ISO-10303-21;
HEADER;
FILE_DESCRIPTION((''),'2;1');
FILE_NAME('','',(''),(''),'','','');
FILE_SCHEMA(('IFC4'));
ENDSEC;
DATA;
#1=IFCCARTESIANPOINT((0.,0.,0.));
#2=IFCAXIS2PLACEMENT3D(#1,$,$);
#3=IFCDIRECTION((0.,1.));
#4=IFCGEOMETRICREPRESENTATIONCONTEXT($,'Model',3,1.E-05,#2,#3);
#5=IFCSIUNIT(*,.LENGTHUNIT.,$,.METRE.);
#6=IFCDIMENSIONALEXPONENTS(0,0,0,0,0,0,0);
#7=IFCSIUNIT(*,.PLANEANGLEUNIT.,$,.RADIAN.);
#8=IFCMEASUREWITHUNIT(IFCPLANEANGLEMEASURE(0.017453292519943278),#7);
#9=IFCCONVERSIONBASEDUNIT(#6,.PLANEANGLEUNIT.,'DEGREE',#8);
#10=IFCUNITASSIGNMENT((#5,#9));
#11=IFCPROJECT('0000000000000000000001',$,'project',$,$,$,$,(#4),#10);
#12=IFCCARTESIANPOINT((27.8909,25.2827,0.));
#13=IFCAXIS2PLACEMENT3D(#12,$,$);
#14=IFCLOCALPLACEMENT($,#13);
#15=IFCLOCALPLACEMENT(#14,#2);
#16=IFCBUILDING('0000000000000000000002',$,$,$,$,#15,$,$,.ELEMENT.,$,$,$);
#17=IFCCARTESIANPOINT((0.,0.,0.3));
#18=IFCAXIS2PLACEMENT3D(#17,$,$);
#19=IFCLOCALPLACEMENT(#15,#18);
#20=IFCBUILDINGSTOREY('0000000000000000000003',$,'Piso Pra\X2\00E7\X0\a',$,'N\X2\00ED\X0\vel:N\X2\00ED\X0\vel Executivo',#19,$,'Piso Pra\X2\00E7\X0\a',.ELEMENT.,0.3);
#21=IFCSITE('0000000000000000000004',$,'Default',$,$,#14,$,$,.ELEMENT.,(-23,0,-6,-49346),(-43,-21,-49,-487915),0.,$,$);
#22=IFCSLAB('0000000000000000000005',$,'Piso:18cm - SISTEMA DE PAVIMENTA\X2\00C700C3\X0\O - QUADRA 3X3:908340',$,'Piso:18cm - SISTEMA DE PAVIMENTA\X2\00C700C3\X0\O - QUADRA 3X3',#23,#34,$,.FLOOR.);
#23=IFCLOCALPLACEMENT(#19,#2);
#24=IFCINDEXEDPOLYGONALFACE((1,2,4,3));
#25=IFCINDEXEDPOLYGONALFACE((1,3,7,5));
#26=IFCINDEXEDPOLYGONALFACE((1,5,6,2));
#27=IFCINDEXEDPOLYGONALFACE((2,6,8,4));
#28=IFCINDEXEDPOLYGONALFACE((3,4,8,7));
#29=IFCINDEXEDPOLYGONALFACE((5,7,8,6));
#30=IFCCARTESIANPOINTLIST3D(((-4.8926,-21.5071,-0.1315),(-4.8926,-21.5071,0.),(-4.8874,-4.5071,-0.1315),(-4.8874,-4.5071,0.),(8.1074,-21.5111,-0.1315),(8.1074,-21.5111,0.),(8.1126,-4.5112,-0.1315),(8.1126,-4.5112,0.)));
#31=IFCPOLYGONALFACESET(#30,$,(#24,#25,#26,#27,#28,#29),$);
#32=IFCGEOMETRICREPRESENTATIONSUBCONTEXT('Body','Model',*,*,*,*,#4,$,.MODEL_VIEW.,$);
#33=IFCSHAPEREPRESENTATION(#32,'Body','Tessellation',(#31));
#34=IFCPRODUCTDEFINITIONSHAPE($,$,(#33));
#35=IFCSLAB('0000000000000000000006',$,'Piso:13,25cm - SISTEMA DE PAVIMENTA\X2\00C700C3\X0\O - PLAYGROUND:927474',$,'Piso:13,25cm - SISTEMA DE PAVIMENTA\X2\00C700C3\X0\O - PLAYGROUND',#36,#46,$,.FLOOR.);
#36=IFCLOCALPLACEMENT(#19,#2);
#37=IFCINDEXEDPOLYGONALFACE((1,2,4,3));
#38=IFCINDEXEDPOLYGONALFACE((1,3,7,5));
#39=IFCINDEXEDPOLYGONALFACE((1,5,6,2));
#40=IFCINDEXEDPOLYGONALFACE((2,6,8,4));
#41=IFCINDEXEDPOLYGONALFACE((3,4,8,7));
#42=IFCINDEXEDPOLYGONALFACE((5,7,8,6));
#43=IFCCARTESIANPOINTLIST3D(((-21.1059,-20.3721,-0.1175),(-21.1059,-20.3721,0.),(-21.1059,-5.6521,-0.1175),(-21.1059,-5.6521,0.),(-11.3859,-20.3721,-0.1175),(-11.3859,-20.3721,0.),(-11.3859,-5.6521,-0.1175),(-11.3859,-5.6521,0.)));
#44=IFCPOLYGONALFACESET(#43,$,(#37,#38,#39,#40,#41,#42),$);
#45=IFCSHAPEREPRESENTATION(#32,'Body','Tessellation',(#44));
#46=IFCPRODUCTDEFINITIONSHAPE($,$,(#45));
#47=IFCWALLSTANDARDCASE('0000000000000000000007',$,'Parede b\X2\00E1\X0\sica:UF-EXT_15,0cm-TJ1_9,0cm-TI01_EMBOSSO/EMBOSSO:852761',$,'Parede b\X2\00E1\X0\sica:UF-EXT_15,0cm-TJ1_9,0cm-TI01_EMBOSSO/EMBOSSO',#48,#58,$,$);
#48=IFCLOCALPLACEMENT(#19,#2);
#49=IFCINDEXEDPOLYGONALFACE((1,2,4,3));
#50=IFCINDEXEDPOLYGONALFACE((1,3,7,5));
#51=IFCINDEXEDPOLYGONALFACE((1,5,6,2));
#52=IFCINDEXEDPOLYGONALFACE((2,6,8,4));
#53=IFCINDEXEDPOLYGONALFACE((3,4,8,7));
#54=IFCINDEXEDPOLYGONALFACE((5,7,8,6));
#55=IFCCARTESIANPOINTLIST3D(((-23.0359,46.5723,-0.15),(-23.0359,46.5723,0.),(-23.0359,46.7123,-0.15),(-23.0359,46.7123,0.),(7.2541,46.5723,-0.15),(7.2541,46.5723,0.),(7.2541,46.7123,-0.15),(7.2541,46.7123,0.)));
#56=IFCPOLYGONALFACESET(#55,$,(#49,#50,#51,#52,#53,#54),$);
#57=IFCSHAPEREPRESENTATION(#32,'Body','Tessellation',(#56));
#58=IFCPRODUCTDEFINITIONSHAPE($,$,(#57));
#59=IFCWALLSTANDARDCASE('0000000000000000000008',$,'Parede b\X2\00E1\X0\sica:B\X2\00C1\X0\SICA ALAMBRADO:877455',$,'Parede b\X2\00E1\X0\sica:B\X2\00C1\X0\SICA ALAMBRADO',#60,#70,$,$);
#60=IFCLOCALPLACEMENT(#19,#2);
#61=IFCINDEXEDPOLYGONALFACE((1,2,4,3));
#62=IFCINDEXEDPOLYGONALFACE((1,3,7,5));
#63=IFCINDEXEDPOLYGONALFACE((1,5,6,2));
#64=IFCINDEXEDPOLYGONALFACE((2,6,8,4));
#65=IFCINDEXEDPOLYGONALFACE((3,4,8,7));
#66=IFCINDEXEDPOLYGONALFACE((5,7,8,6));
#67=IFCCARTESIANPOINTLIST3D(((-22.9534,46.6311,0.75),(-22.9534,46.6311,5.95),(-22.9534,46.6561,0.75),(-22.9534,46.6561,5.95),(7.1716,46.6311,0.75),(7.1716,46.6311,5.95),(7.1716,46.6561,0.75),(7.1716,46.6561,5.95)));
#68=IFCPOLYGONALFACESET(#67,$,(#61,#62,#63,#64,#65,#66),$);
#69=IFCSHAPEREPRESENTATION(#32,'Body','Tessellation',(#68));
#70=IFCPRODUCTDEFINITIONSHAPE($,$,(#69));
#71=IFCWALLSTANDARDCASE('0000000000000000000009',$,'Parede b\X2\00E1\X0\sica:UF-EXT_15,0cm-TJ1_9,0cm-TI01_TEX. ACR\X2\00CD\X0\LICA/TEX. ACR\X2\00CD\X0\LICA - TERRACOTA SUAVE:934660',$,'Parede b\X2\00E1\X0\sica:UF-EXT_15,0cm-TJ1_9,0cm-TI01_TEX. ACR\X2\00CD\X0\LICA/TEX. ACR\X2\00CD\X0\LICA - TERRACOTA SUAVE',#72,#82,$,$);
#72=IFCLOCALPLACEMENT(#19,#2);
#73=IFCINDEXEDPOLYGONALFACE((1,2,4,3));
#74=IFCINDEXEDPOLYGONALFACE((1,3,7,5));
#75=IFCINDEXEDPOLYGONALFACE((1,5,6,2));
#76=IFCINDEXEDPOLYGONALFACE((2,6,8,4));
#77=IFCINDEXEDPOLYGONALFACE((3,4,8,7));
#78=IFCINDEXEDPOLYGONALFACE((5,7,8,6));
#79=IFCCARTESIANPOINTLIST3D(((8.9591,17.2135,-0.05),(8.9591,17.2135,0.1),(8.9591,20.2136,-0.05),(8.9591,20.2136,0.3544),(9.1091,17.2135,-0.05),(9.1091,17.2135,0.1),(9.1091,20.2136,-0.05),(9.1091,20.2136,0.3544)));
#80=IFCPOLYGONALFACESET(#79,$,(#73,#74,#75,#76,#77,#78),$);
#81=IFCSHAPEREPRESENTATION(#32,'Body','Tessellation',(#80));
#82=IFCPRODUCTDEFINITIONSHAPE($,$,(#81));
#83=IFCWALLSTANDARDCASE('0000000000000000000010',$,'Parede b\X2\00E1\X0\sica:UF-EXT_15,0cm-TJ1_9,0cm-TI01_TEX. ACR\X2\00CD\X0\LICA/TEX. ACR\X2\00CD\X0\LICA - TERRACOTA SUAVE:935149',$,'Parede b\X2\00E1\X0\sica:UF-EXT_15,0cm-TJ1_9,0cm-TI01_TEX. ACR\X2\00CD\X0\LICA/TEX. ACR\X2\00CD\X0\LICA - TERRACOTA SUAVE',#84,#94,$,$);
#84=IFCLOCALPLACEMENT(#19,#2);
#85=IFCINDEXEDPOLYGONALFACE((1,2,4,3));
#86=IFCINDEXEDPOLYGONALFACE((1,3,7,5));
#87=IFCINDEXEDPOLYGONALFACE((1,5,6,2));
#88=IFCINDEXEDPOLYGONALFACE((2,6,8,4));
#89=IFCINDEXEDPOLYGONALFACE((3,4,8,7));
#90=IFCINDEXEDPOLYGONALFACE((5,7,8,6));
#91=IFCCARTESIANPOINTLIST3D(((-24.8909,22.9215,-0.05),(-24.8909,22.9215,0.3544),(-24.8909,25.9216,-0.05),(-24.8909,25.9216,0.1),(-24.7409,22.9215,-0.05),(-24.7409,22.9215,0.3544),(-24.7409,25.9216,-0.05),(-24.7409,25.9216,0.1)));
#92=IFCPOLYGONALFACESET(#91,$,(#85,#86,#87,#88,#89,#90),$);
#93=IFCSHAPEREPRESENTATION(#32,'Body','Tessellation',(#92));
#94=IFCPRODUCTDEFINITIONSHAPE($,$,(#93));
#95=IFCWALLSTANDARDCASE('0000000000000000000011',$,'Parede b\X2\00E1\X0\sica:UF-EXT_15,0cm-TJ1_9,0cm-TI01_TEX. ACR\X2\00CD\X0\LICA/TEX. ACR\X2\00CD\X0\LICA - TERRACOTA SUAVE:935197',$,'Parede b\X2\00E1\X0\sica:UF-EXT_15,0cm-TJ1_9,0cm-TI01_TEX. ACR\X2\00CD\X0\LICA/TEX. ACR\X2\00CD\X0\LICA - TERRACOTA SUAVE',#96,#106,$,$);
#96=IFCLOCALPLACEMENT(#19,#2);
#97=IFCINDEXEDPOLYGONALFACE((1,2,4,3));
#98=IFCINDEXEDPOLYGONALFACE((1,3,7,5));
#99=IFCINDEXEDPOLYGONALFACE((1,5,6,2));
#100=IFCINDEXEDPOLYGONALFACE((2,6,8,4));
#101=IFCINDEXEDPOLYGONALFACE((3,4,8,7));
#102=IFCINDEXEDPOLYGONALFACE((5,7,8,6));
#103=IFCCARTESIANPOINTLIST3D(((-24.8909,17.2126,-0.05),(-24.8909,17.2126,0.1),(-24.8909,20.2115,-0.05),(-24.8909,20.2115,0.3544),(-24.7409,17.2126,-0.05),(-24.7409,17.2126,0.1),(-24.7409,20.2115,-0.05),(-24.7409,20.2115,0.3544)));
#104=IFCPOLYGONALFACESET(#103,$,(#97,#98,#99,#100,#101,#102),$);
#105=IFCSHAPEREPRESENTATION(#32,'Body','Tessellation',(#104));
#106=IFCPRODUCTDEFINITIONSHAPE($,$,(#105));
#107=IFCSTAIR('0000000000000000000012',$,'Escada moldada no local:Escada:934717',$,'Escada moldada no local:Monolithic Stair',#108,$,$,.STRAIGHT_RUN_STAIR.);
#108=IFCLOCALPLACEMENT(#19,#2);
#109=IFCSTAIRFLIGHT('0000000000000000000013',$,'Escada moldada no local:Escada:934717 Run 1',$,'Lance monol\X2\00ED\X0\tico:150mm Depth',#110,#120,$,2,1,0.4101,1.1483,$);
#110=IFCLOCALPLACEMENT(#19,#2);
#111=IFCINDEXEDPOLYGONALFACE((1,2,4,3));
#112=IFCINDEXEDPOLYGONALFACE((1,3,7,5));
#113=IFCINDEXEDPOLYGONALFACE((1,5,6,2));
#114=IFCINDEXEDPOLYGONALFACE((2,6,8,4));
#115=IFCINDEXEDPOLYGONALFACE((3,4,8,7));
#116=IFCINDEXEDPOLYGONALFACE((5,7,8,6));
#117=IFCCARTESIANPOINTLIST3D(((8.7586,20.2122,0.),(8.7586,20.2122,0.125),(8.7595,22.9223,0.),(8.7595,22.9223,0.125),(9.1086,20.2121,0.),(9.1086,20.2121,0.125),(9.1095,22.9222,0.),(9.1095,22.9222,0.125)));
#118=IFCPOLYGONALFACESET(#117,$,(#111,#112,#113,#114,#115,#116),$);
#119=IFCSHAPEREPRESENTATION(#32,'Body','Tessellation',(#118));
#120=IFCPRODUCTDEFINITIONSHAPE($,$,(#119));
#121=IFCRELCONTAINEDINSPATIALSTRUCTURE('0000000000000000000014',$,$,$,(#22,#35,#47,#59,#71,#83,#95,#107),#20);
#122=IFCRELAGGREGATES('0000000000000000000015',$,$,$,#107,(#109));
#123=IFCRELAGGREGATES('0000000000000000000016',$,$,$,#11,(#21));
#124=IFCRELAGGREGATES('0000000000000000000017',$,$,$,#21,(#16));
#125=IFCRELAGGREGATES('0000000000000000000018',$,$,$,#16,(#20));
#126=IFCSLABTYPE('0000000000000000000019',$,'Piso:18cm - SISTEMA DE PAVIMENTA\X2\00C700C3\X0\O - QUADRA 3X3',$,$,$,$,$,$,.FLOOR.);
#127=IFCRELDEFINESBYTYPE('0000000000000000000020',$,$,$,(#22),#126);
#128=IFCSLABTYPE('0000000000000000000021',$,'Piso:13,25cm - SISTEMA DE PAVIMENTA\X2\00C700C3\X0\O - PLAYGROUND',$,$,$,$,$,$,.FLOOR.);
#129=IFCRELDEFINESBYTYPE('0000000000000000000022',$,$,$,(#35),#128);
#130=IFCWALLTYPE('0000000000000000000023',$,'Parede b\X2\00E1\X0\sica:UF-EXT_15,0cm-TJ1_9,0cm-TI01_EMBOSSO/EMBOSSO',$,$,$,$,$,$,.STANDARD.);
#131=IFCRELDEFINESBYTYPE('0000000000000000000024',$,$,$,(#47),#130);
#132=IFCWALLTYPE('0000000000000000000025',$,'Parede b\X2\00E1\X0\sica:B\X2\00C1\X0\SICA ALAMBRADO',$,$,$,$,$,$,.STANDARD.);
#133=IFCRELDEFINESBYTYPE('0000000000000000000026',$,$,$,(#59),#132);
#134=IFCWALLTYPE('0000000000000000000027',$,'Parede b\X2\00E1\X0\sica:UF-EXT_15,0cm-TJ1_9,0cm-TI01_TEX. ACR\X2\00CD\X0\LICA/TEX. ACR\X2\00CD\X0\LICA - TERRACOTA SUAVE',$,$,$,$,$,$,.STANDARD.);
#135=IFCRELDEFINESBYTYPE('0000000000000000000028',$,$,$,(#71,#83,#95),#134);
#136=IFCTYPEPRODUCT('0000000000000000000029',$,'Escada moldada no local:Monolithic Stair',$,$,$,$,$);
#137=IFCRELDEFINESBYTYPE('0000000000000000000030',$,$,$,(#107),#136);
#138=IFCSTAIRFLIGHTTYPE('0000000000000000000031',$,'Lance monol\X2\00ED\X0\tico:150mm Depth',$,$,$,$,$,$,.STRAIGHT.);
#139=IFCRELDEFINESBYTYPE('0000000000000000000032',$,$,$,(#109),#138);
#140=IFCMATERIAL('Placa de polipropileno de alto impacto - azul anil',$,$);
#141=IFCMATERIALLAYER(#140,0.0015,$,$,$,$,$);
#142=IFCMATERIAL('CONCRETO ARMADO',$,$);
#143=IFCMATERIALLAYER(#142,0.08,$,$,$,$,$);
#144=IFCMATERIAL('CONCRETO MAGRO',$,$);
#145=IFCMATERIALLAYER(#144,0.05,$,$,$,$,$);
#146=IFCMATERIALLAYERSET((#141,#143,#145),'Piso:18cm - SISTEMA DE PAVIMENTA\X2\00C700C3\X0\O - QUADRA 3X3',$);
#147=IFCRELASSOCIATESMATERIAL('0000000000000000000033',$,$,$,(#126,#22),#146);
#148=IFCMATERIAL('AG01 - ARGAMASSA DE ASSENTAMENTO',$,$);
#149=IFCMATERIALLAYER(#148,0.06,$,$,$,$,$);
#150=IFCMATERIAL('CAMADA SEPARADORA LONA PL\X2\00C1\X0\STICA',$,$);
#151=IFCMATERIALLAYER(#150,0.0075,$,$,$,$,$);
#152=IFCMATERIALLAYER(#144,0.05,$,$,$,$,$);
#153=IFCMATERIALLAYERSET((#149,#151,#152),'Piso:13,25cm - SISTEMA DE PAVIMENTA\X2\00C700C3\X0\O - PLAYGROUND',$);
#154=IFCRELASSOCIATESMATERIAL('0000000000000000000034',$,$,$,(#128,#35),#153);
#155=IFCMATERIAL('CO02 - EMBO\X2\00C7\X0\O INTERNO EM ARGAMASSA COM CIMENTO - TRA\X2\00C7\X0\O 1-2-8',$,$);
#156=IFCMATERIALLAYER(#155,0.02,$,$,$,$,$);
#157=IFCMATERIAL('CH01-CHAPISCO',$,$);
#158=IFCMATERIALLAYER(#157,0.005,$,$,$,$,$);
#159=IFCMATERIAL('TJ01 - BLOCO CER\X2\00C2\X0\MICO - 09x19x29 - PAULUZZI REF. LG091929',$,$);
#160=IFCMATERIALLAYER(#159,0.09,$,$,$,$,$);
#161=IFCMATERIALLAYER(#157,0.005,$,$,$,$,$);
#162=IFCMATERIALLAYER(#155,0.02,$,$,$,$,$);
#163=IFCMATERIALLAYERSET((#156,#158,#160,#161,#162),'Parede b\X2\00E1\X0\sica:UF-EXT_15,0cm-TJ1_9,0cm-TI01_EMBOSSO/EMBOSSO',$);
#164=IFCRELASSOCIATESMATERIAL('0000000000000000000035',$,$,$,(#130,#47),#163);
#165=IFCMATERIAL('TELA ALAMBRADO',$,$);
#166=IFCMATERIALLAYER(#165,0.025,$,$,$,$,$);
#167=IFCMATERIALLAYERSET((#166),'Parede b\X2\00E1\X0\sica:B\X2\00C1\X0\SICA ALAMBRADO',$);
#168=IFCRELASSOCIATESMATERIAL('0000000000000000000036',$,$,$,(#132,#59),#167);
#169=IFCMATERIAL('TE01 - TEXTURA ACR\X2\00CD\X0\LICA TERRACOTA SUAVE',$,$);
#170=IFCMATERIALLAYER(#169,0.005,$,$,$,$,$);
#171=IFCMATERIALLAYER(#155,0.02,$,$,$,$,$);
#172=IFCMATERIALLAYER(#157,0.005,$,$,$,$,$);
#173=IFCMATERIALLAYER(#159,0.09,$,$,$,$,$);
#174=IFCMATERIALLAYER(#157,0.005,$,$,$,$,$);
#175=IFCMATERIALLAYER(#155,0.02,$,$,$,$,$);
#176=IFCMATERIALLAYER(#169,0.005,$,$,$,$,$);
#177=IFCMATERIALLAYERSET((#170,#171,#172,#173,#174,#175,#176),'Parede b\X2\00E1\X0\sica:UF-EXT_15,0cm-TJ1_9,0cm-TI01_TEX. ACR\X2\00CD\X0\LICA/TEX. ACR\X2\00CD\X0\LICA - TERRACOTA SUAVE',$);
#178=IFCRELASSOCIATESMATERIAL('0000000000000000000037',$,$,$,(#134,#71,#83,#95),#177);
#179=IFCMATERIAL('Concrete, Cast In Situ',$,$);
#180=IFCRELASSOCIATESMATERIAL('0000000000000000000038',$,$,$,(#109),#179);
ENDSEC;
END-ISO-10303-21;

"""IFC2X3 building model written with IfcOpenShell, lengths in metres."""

from ifc_helpers import new_model, entity, si_unit, converted_unit, direction, frame, frame_2d, origin, origin_2d_with_axis, place, context, subcontext, project, spatial, rectangle, extrude, clip, halfspace, material, layer, layer_set, layer_usage, type_object, element, aggregate, save


model = new_model("IFC2X3")

# Units and contexts
model_context = context("Model", 3, precision=1e-05, world=origin(), true_north=direction((0.0, 1.0)))
body_context = subcontext(model_context, "Body", "Model", "MODEL_VIEW")
ifc_project = project(units=[si_unit("LENGTHUNIT", "METRE"), converted_unit("PLANEANGLEUNIT", "DEGREE", entity("IfcPlaneAngleMeasure", 0.017453292519943278), si_unit("PLANEANGLEUNIT", "RADIAN"), dimensions=[0, 0, 0, 0, 0, 0, 0])], contexts=[model_context])

# Site, building, storey
site_placement = place(None, frame((27.8909, 25.2827, 0.0)))
site = spatial("IfcSite", under=ifc_project, at=site_placement, Name="Default", CompositionType="ELEMENT", RefLatitude=(-23, 0, -6, -49346), RefLongitude=(-43, -21, -49, -487915), RefElevation=0.0)
building_placement = place(site_placement, origin())
building = spatial("IfcBuilding", under=site, at=building_placement, CompositionType="ELEMENT")
storey_placement = place(building_placement, frame((0.0, 0.0, 0.3)))
storey = spatial("IfcBuildingStorey", under=building, at=storey_placement, Name="Piso Praça", ObjectType="Nível:Nível Executivo", LongName="Piso Praça", CompositionType="ELEMENT", Elevation=0.3)

# Slabs
ifc_material_1 = material(Name="CONCRETO ARMADO")
ifc_material_2 = material(Name="CONCRETO MAGRO")
ifc_material_3 = material(Name="Placa de polipropileno de alto impacto - azul anil")
ifc_layer_1 = layer(ifc_material_3, 0.0015)
ifc_layer_2 = layer(ifc_material_1, 0.08)
ifc_layer_3 = layer(ifc_material_2, 0.05)
ifc_layer_set_1 = layer_set([ifc_layer_1, ifc_layer_2, ifc_layer_3], Name="Piso:18cm - SISTEMA DE PAVIMENTAÇÃO - QUADRA 3X3")
ifc_layer_usage_1 = layer_usage(ifc_layer_set_1, "AXIS3", "POSITIVE", 0.0)
slab_type_1 = type_object("IfcSlabType", Name="Piso:18cm - SISTEMA DE PAVIMENTAÇÃO - QUADRA 3X3", PredefinedType="FLOOR", material=ifc_layer_set_1)
slab_1_placement = place(storey_placement, origin())
element("IfcSlab", 1, at=slab_1_placement, inside=storey, type_object=slab_type_1, material=ifc_layer_usage_1, Name="Piso:18cm - SISTEMA DE PAVIMENTAÇÃO - QUADRA 3X3:908340", ObjectType="Piso:18cm - SISTEMA DE PAVIMENTAÇÃO - QUADRA 3X3", PredefinedType="FLOOR", context=body_context, shape_type="SweptSolid", body=[
    extrude(rectangle(XDim=13.0, YDim=17.0, at=frame_2d((0.0, 0.0), x_axis=(1.0, 0.0))), frame((1.61, -13.0091, 0.0), z_axis=(0.0, 0.0, -1.0), x_axis=(1.0, -0.00031, 0.0)), (0.0, 0.0, 1.0), 0.1315),
])
ifc_material_4 = material(Name="AG01 - ARGAMASSA DE ASSENTAMENTO")
ifc_layer_4 = layer(ifc_material_4, 0.06)
ifc_material_5 = material(Name="CAMADA SEPARADORA LONA PLÁSTICA")
ifc_layer_5 = layer(ifc_material_5, 0.0075)
ifc_layer_6 = layer(ifc_material_2, 0.05)
ifc_layer_set_2 = layer_set([ifc_layer_4, ifc_layer_5, ifc_layer_6], Name="Piso:13,25cm - SISTEMA DE PAVIMENTAÇÃO - PLAYGROUND")
ifc_layer_usage_2 = layer_usage(ifc_layer_set_2, "AXIS3", "POSITIVE", 0.0)
slab_type_2 = type_object("IfcSlabType", Name="Piso:13,25cm - SISTEMA DE PAVIMENTAÇÃO - PLAYGROUND", PredefinedType="FLOOR", material=ifc_layer_set_2)
slab_2_placement = place(storey_placement, origin())
element("IfcSlab", 2, at=slab_2_placement, inside=storey, type_object=slab_type_2, material=ifc_layer_usage_2, Name="Piso:13,25cm - SISTEMA DE PAVIMENTAÇÃO - PLAYGROUND:927474", ObjectType="Piso:13,25cm - SISTEMA DE PAVIMENTAÇÃO - PLAYGROUND", PredefinedType="FLOOR", context=body_context, shape_type="SweptSolid", body=[
    extrude(rectangle(XDim=14.72, YDim=9.72, at=origin_2d_with_axis()), frame((-16.2459, -13.0121, 0.0), z_axis=(0.0, 0.0, -1.0), x_axis=(0.0, 1.0, 0.0)), (0.0, 0.0, 1.0), 0.1175),
])

# Walls
ifc_material_6 = material(Name="CO02 - EMBOÇO INTERNO EM ARGAMASSA COM CIMENTO - TRAÇO 1-2-8")
ifc_layer_7 = layer(ifc_material_6, 0.02)
ifc_material_7 = material(Name="CH01-CHAPISCO")
ifc_layer_8 = layer(ifc_material_7, 0.005)
ifc_material_8 = material(Name="TJ01 - BLOCO CERÂMICO - 09x19x29 - PAULUZZI REF. LG091929")
ifc_layer_9 = layer(ifc_material_8, 0.09)
ifc_layer_10 = layer(ifc_material_7, 0.005)
ifc_layer_11 = layer(ifc_material_6, 0.02)
ifc_layer_set_3 = layer_set([ifc_layer_7, ifc_layer_8, ifc_layer_9, ifc_layer_10, ifc_layer_11], Name="Parede básica:UF-EXT_15,0cm-TJ1_9,0cm-TI01_EMBOSSO/EMBOSSO")
ifc_layer_usage_3 = layer_usage(ifc_layer_set_3, "AXIS2", "NEGATIVE", 0.07)
wall_type_1 = type_object("IfcWallType", Name="Parede básica:UF-EXT_15,0cm-TJ1_9,0cm-TI01_EMBOSSO/EMBOSSO", PredefinedType="STANDARD", material=ifc_layer_set_3)
wall_1_placement = place(storey_placement, frame((-23.0359, 46.6423, -0.15)))
element("IfcWallStandardCase", 3, at=wall_1_placement, inside=storey, type_object=wall_type_1, material=ifc_layer_usage_3, Name="Parede básica:UF-EXT_15,0cm-TJ1_9,0cm-TI01_EMBOSSO/EMBOSSO:852761", ObjectType="Parede básica:UF-EXT_15,0cm-TJ1_9,0cm-TI01_EMBOSSO/EMBOSSO", context=body_context, shape_type="SweptSolid", body=[
    extrude(rectangle(XDim=30.29, YDim=0.14, at=frame_2d((15.145, 0.0), x_axis=(-1.0, 0.0))), origin(), (0.0, 0.0, 1.0), 0.15),
])
ifc_material_9 = material(Name="TELA ALAMBRADO")
ifc_layer_12 = layer(ifc_material_9, 0.025)
ifc_layer_set_4 = layer_set([ifc_layer_12], Name="Parede básica:BÁSICA ALAMBRADO")
ifc_layer_usage_4 = layer_usage(ifc_layer_set_4, "AXIS2", "NEGATIVE", 0.0125)
wall_type_2 = type_object("IfcWallType", Name="Parede básica:BÁSICA ALAMBRADO", PredefinedType="STANDARD", material=ifc_layer_set_4)
wall_2_placement = place(storey_placement, frame((-22.9534, 46.6436, 0.75)))
element("IfcWallStandardCase", 4, at=wall_2_placement, inside=storey, type_object=wall_type_2, material=ifc_layer_usage_4, Name="Parede básica:BÁSICA ALAMBRADO:877455", ObjectType="Parede básica:BÁSICA ALAMBRADO", context=body_context, shape_type="SweptSolid", body=[
    extrude(rectangle(XDim=30.125, YDim=0.025, at=frame_2d((15.0625, 0.0), x_axis=(-1.0, 0.0))), origin(), (0.0, 0.0, 1.0), 5.2),
])

# Walls
ifc_material_10 = material(Name="TE01 - TEXTURA ACRÍLICA TERRACOTA SUAVE")
ifc_layer_13 = layer(ifc_material_10, 0.005)
ifc_layer_14 = layer(ifc_material_6, 0.02)
ifc_layer_15 = layer(ifc_material_7, 0.005)
ifc_layer_16 = layer(ifc_material_8, 0.09)
ifc_layer_17 = layer(ifc_material_7, 0.005)
ifc_layer_18 = layer(ifc_material_6, 0.02)
ifc_layer_19 = layer(ifc_material_10, 0.005)
ifc_layer_set_5 = layer_set([ifc_layer_13, ifc_layer_14, ifc_layer_15, ifc_layer_16, ifc_layer_17, ifc_layer_18, ifc_layer_19], Name="Parede básica:UF-EXT_15,0cm-TJ1_9,0cm-TI01_TEX. ACRÍLICA/TEX. ACRÍLICA - TERRACOTA SUAVE")
ifc_layer_usage_5 = layer_usage(ifc_layer_set_5, "AXIS2", "NEGATIVE", 0.075)
wall_type_3 = type_object("IfcWallType", Name="Parede básica:UF-EXT_15,0cm-TJ1_9,0cm-TI01_TEX. ACRÍLICA/TEX. ACRÍLICA - TERRACOTA SUAVE", PredefinedType="STANDARD", material=ifc_layer_set_5)
wall_3_placement = place(storey_placement, frame((9.0341, 20.2136, -0.05), z_axis=(0.0, 0.0, 1.0), x_axis=(0.0, -1.0, 0.0)))
element("IfcWallStandardCase", 5, at=wall_3_placement, inside=storey, type_object=wall_type_3, material=ifc_layer_usage_5, Name="Parede básica:UF-EXT_15,0cm-TJ1_9,0cm-TI01_TEX. ACRÍLICA/TEX. ACRÍLICA - TERRACOTA SUAVE:934660", ObjectType="Parede básica:UF-EXT_15,0cm-TJ1_9,0cm-TI01_TEX. ACRÍLICA/TEX. ACRÍLICA - TERRACOTA SUAVE", context=body_context, shape_type="Clipping", body=[
    clip(extrude(rectangle(XDim=3.0001, YDim=0.15, at=frame_2d((1.5, 0.0), x_axis=(-1.0, 0.0))), origin(), (0.0, 0.0, 1.0), 0.4044), halfspace(frame((0.0, -0.075, 0.4044), z_axis=(0.084506, 0.0, 0.996423), x_axis=(0.0, 1.0, 0.0)), False)),
])
wall_4_placement = place(storey_placement, frame((-24.8159, 22.9215, -0.05), z_axis=(0.0, 0.0, 1.0), x_axis=(0.0, 1.0, 0.0)))
element("IfcWallStandardCase", 6, at=wall_4_placement, inside=storey, type_object=wall_type_3, material=ifc_layer_usage_5, Name="Parede básica:UF-EXT_15,0cm-TJ1_9,0cm-TI01_TEX. ACRÍLICA/TEX. ACRÍLICA - TERRACOTA SUAVE:935149", ObjectType="Parede básica:UF-EXT_15,0cm-TJ1_9,0cm-TI01_TEX. ACRÍLICA/TEX. ACRÍLICA - TERRACOTA SUAVE", context=body_context, shape_type="Clipping", body=[
    clip(extrude(rectangle(XDim=3.0001, YDim=0.15, at=frame_2d((1.5001, 0.0), x_axis=(-1.0, 0.0))), origin(), (0.0, 0.0, 1.0), 0.4044), halfspace(frame((0.0, -0.075, 0.4044), z_axis=(0.084504, 0.0, 0.996423), x_axis=(0.0, 1.0, 0.0)), False)),
])
ifc_layer_usage_6 = layer_usage(ifc_layer_set_5, "AXIS2", "POSITIVE", -0.075)
wall_5_placement = place(storey_placement, frame((-24.8159, 20.2115, -0.05), z_axis=(0.0, 0.0, 1.0), x_axis=(0.0, -1.0, 0.0)))
element("IfcWallStandardCase", 7, at=wall_5_placement, inside=storey, type_object=wall_type_3, material=ifc_layer_usage_6, Name="Parede básica:UF-EXT_15,0cm-TJ1_9,0cm-TI01_TEX. ACRÍLICA/TEX. ACRÍLICA - TERRACOTA SUAVE:935197", ObjectType="Parede básica:UF-EXT_15,0cm-TJ1_9,0cm-TI01_TEX. ACRÍLICA/TEX. ACRÍLICA - TERRACOTA SUAVE", context=body_context, shape_type="Clipping", body=[
    clip(extrude(rectangle(XDim=2.9988, YDim=0.15, at=frame_2d((1.4994, 0.0), x_axis=(-1.0, 0.0))), origin(), (0.0, 0.0, 1.0), 0.4044), halfspace(frame((0.0, -0.075, 0.4044), z_axis=(0.08454, 0.0, 0.99642), x_axis=(0.0, 1.0, 0.0)), False)),
])

# Stair, stair flight
type_product = type_object("IfcTypeProduct", Name="Escada moldada no local:Monolithic Stair")
stair_1_placement = place(storey_placement, origin())
stair_1 = element("IfcStair", 8, at=stair_1_placement, inside=storey, type_object=type_product, Name="Escada moldada no local:Escada:934717", ObjectType="Escada moldada no local:Monolithic Stair", ShapeType="STRAIGHT_RUN_STAIR")
ifc_material_11 = material(Name="Concrete, Cast In Situ")
stair_flight_type = type_object("IfcStairFlightType", Name="Lance monolítico:150mm Depth", PredefinedType="STRAIGHT")
stair_flight_1_placement = place(stair_1_placement, origin())
stair_flight_1 = element("IfcStairFlight", 9, at=stair_flight_1_placement, type_object=stair_flight_type, material=ifc_material_11, Name="Escada moldada no local:Escada:934717 Run 1", ObjectType="Lance monolítico:150mm Depth", NumberOfRiser=2, NumberOfTreads=1, RiserHeight=0.4101, TreadLength=1.1483, context=body_context, shape_type="SweptSolid", body=[
    extrude(rectangle(XDim=0.125, YDim=2.71, at=origin_2d_with_axis()), frame((8.7591, 21.5673, 0.0625), z_axis=(1.0, -0.00031, 0.0), x_axis=(0.0, 0.0, -1.0)), (0.0, 0.0, 1.0), 0.35),
])
aggregate(stair_1, [stair_flight_1])

save(model, "model.ifc")
